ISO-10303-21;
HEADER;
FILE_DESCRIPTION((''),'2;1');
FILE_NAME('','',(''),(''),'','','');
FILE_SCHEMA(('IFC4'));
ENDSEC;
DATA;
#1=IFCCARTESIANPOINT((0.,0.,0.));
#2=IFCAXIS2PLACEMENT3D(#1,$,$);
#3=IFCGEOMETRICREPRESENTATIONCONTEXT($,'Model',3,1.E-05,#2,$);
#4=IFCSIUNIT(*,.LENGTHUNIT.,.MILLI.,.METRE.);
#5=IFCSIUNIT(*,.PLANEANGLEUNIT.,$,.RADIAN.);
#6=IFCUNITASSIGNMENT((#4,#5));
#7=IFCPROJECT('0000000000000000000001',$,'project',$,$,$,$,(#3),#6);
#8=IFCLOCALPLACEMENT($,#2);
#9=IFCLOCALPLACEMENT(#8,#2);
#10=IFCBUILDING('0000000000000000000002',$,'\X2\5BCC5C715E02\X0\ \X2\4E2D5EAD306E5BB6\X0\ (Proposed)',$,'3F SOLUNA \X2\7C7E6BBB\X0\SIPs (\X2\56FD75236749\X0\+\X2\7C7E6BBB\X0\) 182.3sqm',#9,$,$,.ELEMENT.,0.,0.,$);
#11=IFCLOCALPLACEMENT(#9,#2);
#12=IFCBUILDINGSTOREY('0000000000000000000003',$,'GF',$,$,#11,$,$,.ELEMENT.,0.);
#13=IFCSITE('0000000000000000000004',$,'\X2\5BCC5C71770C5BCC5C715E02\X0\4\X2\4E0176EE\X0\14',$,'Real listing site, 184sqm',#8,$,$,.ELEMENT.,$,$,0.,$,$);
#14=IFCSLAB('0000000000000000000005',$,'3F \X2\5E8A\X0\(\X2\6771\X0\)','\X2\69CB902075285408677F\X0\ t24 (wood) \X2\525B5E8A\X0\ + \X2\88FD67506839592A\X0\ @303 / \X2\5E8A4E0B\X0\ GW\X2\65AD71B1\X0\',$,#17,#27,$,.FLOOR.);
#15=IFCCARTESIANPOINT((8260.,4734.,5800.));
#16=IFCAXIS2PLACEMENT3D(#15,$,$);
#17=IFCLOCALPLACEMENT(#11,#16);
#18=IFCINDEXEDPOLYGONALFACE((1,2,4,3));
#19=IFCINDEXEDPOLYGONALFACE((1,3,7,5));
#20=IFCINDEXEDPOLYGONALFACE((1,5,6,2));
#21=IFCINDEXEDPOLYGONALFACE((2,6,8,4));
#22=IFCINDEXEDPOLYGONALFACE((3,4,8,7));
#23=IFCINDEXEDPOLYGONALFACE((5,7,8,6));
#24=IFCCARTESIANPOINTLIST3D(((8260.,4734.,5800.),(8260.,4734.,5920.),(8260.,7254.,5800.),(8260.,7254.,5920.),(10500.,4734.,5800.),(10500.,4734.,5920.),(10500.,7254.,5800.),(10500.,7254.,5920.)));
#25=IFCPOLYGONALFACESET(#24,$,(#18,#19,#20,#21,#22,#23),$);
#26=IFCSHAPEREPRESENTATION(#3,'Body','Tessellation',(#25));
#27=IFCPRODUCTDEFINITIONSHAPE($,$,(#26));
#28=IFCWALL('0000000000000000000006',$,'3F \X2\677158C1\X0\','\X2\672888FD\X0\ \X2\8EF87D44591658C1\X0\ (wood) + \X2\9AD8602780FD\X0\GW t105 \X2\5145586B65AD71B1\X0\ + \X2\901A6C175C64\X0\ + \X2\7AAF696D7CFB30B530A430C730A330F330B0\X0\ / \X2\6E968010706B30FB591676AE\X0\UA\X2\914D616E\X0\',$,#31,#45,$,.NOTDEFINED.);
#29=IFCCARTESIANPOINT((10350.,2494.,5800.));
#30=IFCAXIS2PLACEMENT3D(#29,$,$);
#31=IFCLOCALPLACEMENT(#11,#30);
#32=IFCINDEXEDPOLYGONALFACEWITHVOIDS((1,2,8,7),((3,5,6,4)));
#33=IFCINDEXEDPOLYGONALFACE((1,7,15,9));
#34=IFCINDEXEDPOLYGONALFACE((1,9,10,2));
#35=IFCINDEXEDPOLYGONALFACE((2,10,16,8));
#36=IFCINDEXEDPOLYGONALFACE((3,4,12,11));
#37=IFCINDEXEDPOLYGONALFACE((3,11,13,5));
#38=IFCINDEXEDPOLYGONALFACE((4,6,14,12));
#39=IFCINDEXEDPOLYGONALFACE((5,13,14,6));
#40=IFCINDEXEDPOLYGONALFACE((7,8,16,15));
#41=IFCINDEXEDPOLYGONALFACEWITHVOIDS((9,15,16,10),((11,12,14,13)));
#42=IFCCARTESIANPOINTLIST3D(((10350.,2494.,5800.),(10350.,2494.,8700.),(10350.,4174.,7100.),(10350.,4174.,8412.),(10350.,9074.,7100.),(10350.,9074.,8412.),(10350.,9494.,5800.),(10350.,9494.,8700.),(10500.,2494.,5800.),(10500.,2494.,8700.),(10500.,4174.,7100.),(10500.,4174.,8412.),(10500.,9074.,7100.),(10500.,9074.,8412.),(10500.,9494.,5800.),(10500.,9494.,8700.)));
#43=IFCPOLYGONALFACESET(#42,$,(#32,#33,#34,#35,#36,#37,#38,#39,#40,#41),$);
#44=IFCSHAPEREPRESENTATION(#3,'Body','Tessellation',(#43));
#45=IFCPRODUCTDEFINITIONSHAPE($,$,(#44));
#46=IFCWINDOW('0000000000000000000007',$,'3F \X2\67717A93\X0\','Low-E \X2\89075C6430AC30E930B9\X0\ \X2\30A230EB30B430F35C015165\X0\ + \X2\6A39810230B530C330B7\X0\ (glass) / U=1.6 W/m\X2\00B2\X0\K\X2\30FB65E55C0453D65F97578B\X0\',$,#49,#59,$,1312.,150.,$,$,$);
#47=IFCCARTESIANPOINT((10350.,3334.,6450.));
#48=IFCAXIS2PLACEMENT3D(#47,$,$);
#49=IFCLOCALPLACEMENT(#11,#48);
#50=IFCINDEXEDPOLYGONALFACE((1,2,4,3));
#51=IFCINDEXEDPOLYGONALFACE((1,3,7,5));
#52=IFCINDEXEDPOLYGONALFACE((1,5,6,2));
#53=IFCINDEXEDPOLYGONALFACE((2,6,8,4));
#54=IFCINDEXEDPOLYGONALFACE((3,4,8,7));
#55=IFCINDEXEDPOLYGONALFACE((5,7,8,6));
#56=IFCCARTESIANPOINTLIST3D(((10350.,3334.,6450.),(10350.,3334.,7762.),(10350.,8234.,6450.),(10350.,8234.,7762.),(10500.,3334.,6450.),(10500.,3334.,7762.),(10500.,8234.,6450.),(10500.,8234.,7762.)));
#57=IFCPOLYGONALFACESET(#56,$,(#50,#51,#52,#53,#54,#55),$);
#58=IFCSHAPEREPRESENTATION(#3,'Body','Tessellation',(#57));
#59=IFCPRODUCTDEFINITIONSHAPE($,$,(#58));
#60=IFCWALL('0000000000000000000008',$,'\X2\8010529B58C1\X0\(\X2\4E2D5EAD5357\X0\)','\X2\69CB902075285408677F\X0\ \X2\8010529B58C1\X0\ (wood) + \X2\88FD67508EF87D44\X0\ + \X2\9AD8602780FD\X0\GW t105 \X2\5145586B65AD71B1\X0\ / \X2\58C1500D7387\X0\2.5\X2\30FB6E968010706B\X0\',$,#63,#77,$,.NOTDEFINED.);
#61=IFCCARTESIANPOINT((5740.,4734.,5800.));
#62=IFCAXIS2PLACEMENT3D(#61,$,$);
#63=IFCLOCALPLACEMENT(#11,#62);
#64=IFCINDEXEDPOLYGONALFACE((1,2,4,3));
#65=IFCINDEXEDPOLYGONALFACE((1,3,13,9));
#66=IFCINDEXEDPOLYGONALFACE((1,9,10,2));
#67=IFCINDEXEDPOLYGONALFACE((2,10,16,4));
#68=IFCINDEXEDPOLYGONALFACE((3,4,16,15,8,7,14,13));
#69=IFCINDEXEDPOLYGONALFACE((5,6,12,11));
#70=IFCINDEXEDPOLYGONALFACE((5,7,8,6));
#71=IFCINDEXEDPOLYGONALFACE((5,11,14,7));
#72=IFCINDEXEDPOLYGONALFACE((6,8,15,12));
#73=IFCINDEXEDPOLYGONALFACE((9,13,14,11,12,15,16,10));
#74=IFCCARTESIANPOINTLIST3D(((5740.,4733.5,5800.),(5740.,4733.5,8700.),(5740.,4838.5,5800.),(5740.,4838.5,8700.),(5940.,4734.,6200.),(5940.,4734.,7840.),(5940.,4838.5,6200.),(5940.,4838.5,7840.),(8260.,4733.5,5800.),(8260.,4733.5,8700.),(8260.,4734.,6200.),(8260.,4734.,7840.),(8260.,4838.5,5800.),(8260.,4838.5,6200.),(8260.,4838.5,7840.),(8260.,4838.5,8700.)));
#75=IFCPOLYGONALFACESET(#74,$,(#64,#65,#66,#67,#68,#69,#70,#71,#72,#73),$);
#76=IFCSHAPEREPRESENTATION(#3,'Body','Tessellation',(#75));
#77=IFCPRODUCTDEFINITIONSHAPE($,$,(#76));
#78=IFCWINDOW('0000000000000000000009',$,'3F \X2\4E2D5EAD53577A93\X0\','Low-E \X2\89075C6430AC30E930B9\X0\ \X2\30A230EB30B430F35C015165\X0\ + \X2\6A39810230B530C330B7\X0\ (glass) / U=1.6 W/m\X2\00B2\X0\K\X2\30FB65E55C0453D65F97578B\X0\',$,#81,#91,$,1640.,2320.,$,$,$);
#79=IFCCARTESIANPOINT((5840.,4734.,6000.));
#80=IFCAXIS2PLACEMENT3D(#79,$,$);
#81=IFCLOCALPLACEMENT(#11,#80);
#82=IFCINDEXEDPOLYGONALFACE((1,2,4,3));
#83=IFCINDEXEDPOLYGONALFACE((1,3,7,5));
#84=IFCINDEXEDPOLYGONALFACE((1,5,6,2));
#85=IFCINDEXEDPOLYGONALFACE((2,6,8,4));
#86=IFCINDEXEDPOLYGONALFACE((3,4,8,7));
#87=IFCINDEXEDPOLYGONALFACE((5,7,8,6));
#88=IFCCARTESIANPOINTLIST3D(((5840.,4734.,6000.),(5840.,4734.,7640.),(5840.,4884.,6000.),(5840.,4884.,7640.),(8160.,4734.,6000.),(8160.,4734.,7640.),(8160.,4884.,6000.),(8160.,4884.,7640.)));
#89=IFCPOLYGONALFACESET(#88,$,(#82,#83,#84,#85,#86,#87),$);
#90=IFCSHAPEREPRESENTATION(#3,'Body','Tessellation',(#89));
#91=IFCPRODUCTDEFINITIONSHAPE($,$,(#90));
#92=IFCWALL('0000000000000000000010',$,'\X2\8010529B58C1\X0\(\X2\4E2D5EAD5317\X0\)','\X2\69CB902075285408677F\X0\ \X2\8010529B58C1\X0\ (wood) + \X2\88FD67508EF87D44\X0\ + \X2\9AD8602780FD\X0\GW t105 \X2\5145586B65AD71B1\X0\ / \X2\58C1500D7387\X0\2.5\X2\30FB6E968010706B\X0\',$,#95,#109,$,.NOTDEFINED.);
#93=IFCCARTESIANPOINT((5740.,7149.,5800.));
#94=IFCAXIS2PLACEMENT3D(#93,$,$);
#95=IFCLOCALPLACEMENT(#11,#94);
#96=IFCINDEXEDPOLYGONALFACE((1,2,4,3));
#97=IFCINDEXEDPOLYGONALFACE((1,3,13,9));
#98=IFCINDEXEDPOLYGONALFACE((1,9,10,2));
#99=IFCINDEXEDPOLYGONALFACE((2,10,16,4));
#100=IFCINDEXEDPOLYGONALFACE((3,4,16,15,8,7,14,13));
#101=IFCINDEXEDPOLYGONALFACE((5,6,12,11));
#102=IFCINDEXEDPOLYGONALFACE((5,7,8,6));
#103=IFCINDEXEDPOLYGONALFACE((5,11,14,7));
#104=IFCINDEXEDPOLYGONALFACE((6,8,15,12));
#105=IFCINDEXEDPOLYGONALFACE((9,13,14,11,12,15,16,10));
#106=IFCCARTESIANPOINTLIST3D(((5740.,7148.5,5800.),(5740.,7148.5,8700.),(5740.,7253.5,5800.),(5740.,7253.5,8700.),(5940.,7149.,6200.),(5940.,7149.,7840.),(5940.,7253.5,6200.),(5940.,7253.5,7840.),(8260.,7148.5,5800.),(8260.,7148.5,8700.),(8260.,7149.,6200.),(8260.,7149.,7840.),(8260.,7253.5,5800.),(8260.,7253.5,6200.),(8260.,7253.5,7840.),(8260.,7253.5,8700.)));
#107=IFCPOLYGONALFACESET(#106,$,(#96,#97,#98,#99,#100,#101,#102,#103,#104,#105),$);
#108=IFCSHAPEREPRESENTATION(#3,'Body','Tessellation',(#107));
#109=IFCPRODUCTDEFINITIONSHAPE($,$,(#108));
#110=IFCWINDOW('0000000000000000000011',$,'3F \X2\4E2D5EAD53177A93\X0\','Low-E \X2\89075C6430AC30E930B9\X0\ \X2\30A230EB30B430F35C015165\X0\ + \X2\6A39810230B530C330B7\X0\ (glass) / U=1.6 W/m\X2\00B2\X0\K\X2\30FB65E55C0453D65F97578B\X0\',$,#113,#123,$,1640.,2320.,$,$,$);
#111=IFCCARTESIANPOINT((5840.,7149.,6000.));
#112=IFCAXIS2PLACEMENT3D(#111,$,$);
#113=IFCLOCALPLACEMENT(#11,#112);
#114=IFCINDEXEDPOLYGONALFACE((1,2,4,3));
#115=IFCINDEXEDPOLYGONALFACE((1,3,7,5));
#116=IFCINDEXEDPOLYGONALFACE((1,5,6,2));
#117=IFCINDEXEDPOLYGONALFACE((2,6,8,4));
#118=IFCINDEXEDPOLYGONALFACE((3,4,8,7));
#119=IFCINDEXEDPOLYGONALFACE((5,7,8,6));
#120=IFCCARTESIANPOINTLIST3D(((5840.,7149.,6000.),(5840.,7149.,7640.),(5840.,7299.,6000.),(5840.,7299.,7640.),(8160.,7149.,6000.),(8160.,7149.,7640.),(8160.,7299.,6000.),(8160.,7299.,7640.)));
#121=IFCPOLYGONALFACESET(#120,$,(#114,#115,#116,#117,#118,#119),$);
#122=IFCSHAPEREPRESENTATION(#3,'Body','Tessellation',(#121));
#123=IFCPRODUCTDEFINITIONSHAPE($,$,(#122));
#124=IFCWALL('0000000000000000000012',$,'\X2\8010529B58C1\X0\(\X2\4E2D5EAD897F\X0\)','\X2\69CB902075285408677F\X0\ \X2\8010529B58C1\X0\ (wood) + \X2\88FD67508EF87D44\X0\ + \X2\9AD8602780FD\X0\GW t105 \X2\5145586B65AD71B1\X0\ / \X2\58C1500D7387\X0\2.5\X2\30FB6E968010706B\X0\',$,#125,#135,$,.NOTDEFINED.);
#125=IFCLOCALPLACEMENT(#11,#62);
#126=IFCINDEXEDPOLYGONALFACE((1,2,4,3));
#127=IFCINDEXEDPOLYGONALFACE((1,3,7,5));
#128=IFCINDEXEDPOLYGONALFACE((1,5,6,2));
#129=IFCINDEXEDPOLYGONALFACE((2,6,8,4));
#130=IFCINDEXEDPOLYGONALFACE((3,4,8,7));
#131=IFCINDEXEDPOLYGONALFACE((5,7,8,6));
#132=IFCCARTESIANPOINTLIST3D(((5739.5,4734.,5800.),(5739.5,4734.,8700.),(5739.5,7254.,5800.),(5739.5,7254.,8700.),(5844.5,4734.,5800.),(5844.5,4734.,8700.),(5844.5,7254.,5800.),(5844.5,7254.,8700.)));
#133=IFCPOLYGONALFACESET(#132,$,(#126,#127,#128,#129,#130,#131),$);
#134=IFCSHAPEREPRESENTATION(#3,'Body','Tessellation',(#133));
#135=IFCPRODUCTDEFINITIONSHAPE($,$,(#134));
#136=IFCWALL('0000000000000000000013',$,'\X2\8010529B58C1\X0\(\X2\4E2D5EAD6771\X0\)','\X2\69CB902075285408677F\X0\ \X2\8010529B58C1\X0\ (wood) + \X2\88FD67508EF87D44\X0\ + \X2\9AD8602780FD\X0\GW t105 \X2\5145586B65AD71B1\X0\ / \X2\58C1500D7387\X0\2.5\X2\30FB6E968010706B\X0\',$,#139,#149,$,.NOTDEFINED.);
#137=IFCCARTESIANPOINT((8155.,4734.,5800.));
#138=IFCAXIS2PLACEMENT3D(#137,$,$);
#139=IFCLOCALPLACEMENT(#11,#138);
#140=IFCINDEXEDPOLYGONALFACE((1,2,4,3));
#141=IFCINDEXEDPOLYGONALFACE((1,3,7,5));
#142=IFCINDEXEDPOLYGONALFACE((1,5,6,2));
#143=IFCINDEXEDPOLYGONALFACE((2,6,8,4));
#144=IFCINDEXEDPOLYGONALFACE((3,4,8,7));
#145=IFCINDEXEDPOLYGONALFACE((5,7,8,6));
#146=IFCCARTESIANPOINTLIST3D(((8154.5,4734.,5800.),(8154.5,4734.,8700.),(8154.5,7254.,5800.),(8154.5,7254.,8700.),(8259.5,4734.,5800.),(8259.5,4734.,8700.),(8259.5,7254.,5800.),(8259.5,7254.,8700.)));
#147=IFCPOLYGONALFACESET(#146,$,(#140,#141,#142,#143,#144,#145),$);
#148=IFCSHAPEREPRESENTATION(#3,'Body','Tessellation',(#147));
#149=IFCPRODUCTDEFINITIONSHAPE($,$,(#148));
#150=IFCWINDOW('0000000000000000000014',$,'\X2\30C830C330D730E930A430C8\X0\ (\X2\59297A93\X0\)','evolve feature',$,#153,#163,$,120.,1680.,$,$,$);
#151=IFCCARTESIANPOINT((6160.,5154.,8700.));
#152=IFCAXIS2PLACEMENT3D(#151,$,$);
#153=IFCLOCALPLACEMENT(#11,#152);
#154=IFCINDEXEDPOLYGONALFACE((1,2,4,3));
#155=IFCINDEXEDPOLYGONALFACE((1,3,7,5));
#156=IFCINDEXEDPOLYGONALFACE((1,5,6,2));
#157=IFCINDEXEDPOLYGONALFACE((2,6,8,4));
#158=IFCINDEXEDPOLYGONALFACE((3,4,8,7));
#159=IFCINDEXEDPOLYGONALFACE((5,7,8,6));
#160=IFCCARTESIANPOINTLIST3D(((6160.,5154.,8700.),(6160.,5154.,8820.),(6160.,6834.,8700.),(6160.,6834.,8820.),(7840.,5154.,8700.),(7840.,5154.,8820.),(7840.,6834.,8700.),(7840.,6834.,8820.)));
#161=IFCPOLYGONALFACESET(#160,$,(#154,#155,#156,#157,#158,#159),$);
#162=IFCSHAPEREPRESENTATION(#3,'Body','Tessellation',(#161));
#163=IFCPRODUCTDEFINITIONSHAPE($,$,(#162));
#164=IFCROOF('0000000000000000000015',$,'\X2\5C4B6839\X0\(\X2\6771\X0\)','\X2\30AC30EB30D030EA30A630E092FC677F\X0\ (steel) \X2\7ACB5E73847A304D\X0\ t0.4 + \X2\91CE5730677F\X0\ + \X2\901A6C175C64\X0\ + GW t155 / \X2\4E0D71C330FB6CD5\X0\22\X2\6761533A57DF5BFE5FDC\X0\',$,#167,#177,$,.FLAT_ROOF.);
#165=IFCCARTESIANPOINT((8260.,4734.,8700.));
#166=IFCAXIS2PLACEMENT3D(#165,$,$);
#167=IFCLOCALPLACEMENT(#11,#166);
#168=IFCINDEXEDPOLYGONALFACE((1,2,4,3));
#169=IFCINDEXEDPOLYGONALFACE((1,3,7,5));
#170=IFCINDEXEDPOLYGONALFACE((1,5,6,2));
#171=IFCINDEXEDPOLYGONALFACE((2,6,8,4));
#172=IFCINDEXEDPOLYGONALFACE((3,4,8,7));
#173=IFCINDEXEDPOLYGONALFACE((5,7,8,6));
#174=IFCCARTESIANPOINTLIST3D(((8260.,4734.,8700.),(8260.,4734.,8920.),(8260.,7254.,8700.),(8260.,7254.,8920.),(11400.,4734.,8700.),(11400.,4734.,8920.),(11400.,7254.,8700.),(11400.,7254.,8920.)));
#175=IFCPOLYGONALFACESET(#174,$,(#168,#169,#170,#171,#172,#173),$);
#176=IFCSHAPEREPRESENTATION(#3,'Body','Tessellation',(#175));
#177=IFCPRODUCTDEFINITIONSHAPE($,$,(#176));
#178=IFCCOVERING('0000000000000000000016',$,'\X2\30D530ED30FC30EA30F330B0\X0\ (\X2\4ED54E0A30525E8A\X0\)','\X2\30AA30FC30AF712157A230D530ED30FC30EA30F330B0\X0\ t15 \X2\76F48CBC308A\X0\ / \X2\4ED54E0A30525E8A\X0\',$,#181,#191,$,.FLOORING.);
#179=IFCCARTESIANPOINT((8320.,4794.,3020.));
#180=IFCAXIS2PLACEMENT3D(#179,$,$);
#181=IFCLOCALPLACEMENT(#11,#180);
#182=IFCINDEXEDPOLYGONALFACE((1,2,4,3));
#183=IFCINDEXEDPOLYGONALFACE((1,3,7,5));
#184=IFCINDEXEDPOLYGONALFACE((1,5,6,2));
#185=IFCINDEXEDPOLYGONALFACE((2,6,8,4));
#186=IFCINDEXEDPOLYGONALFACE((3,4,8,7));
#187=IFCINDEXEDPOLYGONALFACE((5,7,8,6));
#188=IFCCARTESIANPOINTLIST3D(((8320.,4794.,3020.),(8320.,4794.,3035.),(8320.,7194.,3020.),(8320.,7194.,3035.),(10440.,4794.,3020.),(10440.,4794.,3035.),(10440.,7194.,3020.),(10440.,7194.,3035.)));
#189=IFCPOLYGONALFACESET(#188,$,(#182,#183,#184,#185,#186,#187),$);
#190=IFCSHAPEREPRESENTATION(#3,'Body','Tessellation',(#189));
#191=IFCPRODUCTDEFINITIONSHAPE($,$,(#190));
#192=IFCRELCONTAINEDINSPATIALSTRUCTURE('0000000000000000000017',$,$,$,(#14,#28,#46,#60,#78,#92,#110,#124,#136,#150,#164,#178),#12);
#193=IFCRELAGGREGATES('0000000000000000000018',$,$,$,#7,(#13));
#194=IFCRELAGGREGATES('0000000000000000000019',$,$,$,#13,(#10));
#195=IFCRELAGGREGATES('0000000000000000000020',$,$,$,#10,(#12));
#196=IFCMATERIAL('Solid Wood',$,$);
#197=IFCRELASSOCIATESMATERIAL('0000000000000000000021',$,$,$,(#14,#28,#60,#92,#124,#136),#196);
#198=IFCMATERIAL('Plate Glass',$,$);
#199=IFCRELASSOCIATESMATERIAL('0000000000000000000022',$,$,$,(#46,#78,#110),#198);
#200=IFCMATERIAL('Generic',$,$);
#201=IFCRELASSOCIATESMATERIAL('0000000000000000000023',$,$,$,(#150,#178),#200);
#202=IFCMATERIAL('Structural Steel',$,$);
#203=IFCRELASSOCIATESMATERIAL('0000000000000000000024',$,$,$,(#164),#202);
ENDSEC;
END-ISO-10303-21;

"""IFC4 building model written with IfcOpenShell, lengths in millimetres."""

from ifc_helpers import new_model, si_unit, frame, frame_2d, origin, place, context, project, spatial, rectangle, extrude, material, element, fill, save


model = new_model("IFC4")

# Units and contexts
model_context = context("Model", 3, precision=1e-05, world=origin())
ifc_project = project(units=[si_unit("LENGTHUNIT", "METRE", prefix="MILLI"), si_unit("PLANEANGLEUNIT", "RADIAN")], contexts=[model_context])

# Site, building, storey
site_placement = place(None, origin())
site = spatial("IfcSite", under=ifc_project, at=site_placement, Name="富山県富山市4丁目14", ObjectType="Real listing site, 184sqm", CompositionType="ELEMENT", RefElevation=0.0)
building_placement = place(site_placement, origin())
building = spatial("IfcBuilding", under=site, at=building_placement, Name="富山市 中庭の家 (Proposed)", ObjectType="3F SOLUNA 籾殻SIPs (国産杉+籾殻) 182.3sqm", CompositionType="ELEMENT", ElevationOfRefHeight=0.0, ElevationOfTerrain=0.0)
storey_placement = place(building_placement, origin())
storey = spatial("IfcBuildingStorey", under=building, at=storey_placement, Name="GF", CompositionType="ELEMENT", Elevation=0.0)

# Slab
ifc_material_1 = material(Name="Solid Wood")
slab_placement = place(storey_placement, frame((8260.0, 4734.0, 5800.0)))
element("IfcSlab", 1, at=slab_placement, inside=storey, material=ifc_material_1, Name="3F 床(東)", Description="構造用合板 t24 (wood) 剛床 + 製材根太 @303 / 床下 GW断熱", PredefinedType="FLOOR", context=model_context, shape_type="SweptSolid", body=[
    extrude(rectangle(XDim=2240.0, YDim=2520.0, at=frame_2d((1120.0, 1260.0))), frame((8260.0, 4734.0, 5800.0)), (0.0, 0.0, 1.0), 120.0),
])

# Walls, openings, windows
wall_1_placement = place(storey_placement, frame((10350.0, 2494.0, 5800.0)))
wall_1 = element("IfcWall", 2, at=wall_1_placement, inside=storey, material=ifc_material_1, Name="3F 東壁", Description="木製 軸組外壁 (wood) + 高性能GW t105 充填断熱 + 通気層 + 窯業系サイディング / 準耐火・外皮UA配慮", PredefinedType="NOTDEFINED", context=model_context, shape_type="SweptSolid", body=[
    extrude(rectangle(XDim=150.0, YDim=7000.0, at=frame_2d((75.0, 3500.0))), frame((10350.0, 2494.0, 5800.0)), (0.0, 0.0, 1.0), 2900.0),
])
opening_1_placement = place(storey_placement, frame((10350.0, 3334.0, 6450.0)))
opening_1 = element("IfcOpeningElement", 3, at=opening_1_placement, cuts=wall_1, PredefinedType="NOTDEFINED", context=model_context, shape_type="SweptSolid", body=[
    extrude(rectangle(XDim=150.0, YDim=4900.0, at=frame_2d((75.0, 2450.0))), frame((10350.0, 3334.0, 6450.0)), (0.0, 0.0, 1.0), 1312.0),
])
ifc_material_2 = material(Name="Plate Glass")
window_1_placement = place(storey_placement, frame((10350.0, 3334.0, 6450.0)))
window_1 = element("IfcWindow", 4, at=window_1_placement, inside=storey, material=ifc_material_2, Name="3F 東窓", Description="Low-E 複層ガラス アルゴン封入 + 樹脂サッシ (glass) / U=1.6 W/m²K・日射取得型", OverallHeight=1312.0, OverallWidth=150.0, context=model_context, shape_type="SweptSolid", body=[
    extrude(rectangle(XDim=150.0, YDim=4900.0, at=frame_2d((75.0, 2450.0))), frame((10350.0, 3334.0, 6450.0)), (0.0, 0.0, 1.0), 1312.0),
])
fill(opening_1, window_1)
wall_2_placement = place(storey_placement, frame((5740.0, 4734.0, 5800.0)))
wall_2 = element("IfcWall", 5, at=wall_2_placement, inside=storey, material=ifc_material_1, Name="耐力壁(中庭南)", Description="構造用合板 耐力壁 (wood) + 製材軸組 + 高性能GW t105 充填断熱 / 壁倍率2.5・準耐火", PredefinedType="NOTDEFINED", context=model_context, shape_type="SweptSolid", body=[
    extrude(rectangle(XDim=2520.0, YDim=105.0, at=frame_2d((1260.0, 52.0))), frame((5740.0, 4734.0, 5800.0)), (0.0, 0.0, 1.0), 2900.0),
])
opening_2_placement = place(storey_placement, frame((5840.0, 4734.0, 6000.0)))
opening_2 = element("IfcOpeningElement", 6, at=opening_2_placement, cuts=wall_2, PredefinedType="NOTDEFINED", context=model_context, shape_type="SweptSolid", body=[
    extrude(rectangle(XDim=2320.0, YDim=150.0, at=frame_2d((1160.0, 75.0))), frame((5840.0, 4734.0, 6000.0)), (0.0, 0.0, 1.0), 1640.0),
])
window_2_placement = place(storey_placement, frame((5840.0, 4734.0, 6000.0)))
window_2 = element("IfcWindow", 7, at=window_2_placement, inside=storey, material=ifc_material_2, Name="3F 中庭南窓", Description="Low-E 複層ガラス アルゴン封入 + 樹脂サッシ (glass) / U=1.6 W/m²K・日射取得型", OverallHeight=1640.0, OverallWidth=2320.0, context=model_context, shape_type="SweptSolid", body=[
    extrude(rectangle(XDim=2320.0, YDim=150.0, at=frame_2d((1160.0, 75.0))), frame((5840.0, 4734.0, 6000.0)), (0.0, 0.0, 1.0), 1640.0),
])
fill(opening_2, window_2)
wall_3_placement = place(storey_placement, frame((5740.0, 7149.0, 5800.0)))
wall_3 = element("IfcWall", 8, at=wall_3_placement, inside=storey, material=ifc_material_1, Name="耐力壁(中庭北)", Description="構造用合板 耐力壁 (wood) + 製材軸組 + 高性能GW t105 充填断熱 / 壁倍率2.5・準耐火", PredefinedType="NOTDEFINED", context=model_context, shape_type="SweptSolid", body=[
    extrude(rectangle(XDim=2520.0, YDim=105.0, at=frame_2d((1260.0, 52.0))), frame((5740.0, 7149.0, 5800.0)), (0.0, 0.0, 1.0), 2900.0),
])
opening_3_placement = place(storey_placement, frame((5840.0, 7149.0, 6000.0)))
opening_3 = element("IfcOpeningElement", 9, at=opening_3_placement, cuts=wall_3, PredefinedType="NOTDEFINED", context=model_context, shape_type="SweptSolid", body=[
    extrude(rectangle(XDim=2320.0, YDim=150.0, at=frame_2d((1160.0, 75.0))), frame((5840.0, 7149.0, 6000.0)), (0.0, 0.0, 1.0), 1640.0),
])
window_3_placement = place(storey_placement, frame((5840.0, 7149.0, 6000.0)))
window_3 = element("IfcWindow", 10, at=window_3_placement, inside=storey, material=ifc_material_2, Name="3F 中庭北窓", Description="Low-E 複層ガラス アルゴン封入 + 樹脂サッシ (glass) / U=1.6 W/m²K・日射取得型", OverallHeight=1640.0, OverallWidth=2320.0, context=model_context, shape_type="SweptSolid", body=[
    extrude(rectangle(XDim=2320.0, YDim=150.0, at=frame_2d((1160.0, 75.0))), frame((5840.0, 7149.0, 6000.0)), (0.0, 0.0, 1.0), 1640.0),
])
fill(opening_3, window_3)

# Walls
wall_4_placement = place(storey_placement, frame((5740.0, 4734.0, 5800.0)))
element("IfcWall", 11, at=wall_4_placement, inside=storey, material=ifc_material_1, Name="耐力壁(中庭西)", Description="構造用合板 耐力壁 (wood) + 製材軸組 + 高性能GW t105 充填断熱 / 壁倍率2.5・準耐火", PredefinedType="NOTDEFINED", context=model_context, shape_type="SweptSolid", body=[
    extrude(rectangle(XDim=105.0, YDim=2520.0, at=frame_2d((52.0, 1260.0))), frame((5740.0, 4734.0, 5800.0)), (0.0, 0.0, 1.0), 2900.0),
])
wall_5_placement = place(storey_placement, frame((8155.0, 4734.0, 5800.0)))
element("IfcWall", 12, at=wall_5_placement, inside=storey, material=ifc_material_1, Name="耐力壁(中庭東)", Description="構造用合板 耐力壁 (wood) + 製材軸組 + 高性能GW t105 充填断熱 / 壁倍率2.5・準耐火", PredefinedType="NOTDEFINED", context=model_context, shape_type="SweptSolid", body=[
    extrude(rectangle(XDim=105.0, YDim=2520.0, at=frame_2d((52.0, 1260.0))), frame((8155.0, 4734.0, 5800.0)), (0.0, 0.0, 1.0), 2900.0),
])

# Window
ifc_material_3 = material(Name="Generic")
window_4_placement = place(storey_placement, frame((6160.0, 5154.0, 8700.0)))
element("IfcWindow", 13, at=window_4_placement, inside=storey, material=ifc_material_3, Name="トップライト (天窓)", Description="evolve feature", OverallHeight=120.0, OverallWidth=1680.0, context=model_context, shape_type="SweptSolid", body=[
    extrude(rectangle(XDim=1680.0, YDim=1680.0, at=frame_2d((840.0, 840.0))), frame((6160.0, 5154.0, 8700.0)), (0.0, 0.0, 1.0), 120.0),
])

# Roof
ifc_material_4 = material(Name="Structural Steel")
for number, where, name in (
    (14, (8260.0, 4734.0, 8700.0), "屋根(東)"),
):
    element("IfcRoof", number, at=place(storey_placement, frame(where)), inside=storey, material=ifc_material_4, Name=name, Description="ガルバリウム鋼板 (steel) 立平葺き t0.4 + 野地板 + 通気層 + GW t155 / 不燃・法22条区域対応", PredefinedType="FLAT_ROOF", context=model_context, shape_type="SweptSolid", body=[
        extrude(rectangle(XDim=3140.0, YDim=2520.0, at=frame_2d((1570.0, 1260.0))), frame((8260.0, 4734.0, 8700.0)), (0.0, 0.0, 1.0), 220.0),
    ])

# Covering
covering_1_placement = place(storey_placement, frame((8320.0, 4794.0, 3020.0)))
element("IfcCovering", 15, at=covering_1_placement, inside=storey, material=ifc_material_3, Name="フローリング (仕上げ床)", Description="オーク無垢フローリング t15 直貼り / 仕上げ床", PredefinedType="FLOORING", context=model_context, shape_type="SweptSolid", body=[
    extrude(rectangle(XDim=2120.0, YDim=2400.0, at=frame_2d((1060.0, 1200.0))), frame((8320.0, 4794.0, 3020.0)), (0.0, 0.0, 1.0), 15.0),
])

save(model, "model.ifc")
